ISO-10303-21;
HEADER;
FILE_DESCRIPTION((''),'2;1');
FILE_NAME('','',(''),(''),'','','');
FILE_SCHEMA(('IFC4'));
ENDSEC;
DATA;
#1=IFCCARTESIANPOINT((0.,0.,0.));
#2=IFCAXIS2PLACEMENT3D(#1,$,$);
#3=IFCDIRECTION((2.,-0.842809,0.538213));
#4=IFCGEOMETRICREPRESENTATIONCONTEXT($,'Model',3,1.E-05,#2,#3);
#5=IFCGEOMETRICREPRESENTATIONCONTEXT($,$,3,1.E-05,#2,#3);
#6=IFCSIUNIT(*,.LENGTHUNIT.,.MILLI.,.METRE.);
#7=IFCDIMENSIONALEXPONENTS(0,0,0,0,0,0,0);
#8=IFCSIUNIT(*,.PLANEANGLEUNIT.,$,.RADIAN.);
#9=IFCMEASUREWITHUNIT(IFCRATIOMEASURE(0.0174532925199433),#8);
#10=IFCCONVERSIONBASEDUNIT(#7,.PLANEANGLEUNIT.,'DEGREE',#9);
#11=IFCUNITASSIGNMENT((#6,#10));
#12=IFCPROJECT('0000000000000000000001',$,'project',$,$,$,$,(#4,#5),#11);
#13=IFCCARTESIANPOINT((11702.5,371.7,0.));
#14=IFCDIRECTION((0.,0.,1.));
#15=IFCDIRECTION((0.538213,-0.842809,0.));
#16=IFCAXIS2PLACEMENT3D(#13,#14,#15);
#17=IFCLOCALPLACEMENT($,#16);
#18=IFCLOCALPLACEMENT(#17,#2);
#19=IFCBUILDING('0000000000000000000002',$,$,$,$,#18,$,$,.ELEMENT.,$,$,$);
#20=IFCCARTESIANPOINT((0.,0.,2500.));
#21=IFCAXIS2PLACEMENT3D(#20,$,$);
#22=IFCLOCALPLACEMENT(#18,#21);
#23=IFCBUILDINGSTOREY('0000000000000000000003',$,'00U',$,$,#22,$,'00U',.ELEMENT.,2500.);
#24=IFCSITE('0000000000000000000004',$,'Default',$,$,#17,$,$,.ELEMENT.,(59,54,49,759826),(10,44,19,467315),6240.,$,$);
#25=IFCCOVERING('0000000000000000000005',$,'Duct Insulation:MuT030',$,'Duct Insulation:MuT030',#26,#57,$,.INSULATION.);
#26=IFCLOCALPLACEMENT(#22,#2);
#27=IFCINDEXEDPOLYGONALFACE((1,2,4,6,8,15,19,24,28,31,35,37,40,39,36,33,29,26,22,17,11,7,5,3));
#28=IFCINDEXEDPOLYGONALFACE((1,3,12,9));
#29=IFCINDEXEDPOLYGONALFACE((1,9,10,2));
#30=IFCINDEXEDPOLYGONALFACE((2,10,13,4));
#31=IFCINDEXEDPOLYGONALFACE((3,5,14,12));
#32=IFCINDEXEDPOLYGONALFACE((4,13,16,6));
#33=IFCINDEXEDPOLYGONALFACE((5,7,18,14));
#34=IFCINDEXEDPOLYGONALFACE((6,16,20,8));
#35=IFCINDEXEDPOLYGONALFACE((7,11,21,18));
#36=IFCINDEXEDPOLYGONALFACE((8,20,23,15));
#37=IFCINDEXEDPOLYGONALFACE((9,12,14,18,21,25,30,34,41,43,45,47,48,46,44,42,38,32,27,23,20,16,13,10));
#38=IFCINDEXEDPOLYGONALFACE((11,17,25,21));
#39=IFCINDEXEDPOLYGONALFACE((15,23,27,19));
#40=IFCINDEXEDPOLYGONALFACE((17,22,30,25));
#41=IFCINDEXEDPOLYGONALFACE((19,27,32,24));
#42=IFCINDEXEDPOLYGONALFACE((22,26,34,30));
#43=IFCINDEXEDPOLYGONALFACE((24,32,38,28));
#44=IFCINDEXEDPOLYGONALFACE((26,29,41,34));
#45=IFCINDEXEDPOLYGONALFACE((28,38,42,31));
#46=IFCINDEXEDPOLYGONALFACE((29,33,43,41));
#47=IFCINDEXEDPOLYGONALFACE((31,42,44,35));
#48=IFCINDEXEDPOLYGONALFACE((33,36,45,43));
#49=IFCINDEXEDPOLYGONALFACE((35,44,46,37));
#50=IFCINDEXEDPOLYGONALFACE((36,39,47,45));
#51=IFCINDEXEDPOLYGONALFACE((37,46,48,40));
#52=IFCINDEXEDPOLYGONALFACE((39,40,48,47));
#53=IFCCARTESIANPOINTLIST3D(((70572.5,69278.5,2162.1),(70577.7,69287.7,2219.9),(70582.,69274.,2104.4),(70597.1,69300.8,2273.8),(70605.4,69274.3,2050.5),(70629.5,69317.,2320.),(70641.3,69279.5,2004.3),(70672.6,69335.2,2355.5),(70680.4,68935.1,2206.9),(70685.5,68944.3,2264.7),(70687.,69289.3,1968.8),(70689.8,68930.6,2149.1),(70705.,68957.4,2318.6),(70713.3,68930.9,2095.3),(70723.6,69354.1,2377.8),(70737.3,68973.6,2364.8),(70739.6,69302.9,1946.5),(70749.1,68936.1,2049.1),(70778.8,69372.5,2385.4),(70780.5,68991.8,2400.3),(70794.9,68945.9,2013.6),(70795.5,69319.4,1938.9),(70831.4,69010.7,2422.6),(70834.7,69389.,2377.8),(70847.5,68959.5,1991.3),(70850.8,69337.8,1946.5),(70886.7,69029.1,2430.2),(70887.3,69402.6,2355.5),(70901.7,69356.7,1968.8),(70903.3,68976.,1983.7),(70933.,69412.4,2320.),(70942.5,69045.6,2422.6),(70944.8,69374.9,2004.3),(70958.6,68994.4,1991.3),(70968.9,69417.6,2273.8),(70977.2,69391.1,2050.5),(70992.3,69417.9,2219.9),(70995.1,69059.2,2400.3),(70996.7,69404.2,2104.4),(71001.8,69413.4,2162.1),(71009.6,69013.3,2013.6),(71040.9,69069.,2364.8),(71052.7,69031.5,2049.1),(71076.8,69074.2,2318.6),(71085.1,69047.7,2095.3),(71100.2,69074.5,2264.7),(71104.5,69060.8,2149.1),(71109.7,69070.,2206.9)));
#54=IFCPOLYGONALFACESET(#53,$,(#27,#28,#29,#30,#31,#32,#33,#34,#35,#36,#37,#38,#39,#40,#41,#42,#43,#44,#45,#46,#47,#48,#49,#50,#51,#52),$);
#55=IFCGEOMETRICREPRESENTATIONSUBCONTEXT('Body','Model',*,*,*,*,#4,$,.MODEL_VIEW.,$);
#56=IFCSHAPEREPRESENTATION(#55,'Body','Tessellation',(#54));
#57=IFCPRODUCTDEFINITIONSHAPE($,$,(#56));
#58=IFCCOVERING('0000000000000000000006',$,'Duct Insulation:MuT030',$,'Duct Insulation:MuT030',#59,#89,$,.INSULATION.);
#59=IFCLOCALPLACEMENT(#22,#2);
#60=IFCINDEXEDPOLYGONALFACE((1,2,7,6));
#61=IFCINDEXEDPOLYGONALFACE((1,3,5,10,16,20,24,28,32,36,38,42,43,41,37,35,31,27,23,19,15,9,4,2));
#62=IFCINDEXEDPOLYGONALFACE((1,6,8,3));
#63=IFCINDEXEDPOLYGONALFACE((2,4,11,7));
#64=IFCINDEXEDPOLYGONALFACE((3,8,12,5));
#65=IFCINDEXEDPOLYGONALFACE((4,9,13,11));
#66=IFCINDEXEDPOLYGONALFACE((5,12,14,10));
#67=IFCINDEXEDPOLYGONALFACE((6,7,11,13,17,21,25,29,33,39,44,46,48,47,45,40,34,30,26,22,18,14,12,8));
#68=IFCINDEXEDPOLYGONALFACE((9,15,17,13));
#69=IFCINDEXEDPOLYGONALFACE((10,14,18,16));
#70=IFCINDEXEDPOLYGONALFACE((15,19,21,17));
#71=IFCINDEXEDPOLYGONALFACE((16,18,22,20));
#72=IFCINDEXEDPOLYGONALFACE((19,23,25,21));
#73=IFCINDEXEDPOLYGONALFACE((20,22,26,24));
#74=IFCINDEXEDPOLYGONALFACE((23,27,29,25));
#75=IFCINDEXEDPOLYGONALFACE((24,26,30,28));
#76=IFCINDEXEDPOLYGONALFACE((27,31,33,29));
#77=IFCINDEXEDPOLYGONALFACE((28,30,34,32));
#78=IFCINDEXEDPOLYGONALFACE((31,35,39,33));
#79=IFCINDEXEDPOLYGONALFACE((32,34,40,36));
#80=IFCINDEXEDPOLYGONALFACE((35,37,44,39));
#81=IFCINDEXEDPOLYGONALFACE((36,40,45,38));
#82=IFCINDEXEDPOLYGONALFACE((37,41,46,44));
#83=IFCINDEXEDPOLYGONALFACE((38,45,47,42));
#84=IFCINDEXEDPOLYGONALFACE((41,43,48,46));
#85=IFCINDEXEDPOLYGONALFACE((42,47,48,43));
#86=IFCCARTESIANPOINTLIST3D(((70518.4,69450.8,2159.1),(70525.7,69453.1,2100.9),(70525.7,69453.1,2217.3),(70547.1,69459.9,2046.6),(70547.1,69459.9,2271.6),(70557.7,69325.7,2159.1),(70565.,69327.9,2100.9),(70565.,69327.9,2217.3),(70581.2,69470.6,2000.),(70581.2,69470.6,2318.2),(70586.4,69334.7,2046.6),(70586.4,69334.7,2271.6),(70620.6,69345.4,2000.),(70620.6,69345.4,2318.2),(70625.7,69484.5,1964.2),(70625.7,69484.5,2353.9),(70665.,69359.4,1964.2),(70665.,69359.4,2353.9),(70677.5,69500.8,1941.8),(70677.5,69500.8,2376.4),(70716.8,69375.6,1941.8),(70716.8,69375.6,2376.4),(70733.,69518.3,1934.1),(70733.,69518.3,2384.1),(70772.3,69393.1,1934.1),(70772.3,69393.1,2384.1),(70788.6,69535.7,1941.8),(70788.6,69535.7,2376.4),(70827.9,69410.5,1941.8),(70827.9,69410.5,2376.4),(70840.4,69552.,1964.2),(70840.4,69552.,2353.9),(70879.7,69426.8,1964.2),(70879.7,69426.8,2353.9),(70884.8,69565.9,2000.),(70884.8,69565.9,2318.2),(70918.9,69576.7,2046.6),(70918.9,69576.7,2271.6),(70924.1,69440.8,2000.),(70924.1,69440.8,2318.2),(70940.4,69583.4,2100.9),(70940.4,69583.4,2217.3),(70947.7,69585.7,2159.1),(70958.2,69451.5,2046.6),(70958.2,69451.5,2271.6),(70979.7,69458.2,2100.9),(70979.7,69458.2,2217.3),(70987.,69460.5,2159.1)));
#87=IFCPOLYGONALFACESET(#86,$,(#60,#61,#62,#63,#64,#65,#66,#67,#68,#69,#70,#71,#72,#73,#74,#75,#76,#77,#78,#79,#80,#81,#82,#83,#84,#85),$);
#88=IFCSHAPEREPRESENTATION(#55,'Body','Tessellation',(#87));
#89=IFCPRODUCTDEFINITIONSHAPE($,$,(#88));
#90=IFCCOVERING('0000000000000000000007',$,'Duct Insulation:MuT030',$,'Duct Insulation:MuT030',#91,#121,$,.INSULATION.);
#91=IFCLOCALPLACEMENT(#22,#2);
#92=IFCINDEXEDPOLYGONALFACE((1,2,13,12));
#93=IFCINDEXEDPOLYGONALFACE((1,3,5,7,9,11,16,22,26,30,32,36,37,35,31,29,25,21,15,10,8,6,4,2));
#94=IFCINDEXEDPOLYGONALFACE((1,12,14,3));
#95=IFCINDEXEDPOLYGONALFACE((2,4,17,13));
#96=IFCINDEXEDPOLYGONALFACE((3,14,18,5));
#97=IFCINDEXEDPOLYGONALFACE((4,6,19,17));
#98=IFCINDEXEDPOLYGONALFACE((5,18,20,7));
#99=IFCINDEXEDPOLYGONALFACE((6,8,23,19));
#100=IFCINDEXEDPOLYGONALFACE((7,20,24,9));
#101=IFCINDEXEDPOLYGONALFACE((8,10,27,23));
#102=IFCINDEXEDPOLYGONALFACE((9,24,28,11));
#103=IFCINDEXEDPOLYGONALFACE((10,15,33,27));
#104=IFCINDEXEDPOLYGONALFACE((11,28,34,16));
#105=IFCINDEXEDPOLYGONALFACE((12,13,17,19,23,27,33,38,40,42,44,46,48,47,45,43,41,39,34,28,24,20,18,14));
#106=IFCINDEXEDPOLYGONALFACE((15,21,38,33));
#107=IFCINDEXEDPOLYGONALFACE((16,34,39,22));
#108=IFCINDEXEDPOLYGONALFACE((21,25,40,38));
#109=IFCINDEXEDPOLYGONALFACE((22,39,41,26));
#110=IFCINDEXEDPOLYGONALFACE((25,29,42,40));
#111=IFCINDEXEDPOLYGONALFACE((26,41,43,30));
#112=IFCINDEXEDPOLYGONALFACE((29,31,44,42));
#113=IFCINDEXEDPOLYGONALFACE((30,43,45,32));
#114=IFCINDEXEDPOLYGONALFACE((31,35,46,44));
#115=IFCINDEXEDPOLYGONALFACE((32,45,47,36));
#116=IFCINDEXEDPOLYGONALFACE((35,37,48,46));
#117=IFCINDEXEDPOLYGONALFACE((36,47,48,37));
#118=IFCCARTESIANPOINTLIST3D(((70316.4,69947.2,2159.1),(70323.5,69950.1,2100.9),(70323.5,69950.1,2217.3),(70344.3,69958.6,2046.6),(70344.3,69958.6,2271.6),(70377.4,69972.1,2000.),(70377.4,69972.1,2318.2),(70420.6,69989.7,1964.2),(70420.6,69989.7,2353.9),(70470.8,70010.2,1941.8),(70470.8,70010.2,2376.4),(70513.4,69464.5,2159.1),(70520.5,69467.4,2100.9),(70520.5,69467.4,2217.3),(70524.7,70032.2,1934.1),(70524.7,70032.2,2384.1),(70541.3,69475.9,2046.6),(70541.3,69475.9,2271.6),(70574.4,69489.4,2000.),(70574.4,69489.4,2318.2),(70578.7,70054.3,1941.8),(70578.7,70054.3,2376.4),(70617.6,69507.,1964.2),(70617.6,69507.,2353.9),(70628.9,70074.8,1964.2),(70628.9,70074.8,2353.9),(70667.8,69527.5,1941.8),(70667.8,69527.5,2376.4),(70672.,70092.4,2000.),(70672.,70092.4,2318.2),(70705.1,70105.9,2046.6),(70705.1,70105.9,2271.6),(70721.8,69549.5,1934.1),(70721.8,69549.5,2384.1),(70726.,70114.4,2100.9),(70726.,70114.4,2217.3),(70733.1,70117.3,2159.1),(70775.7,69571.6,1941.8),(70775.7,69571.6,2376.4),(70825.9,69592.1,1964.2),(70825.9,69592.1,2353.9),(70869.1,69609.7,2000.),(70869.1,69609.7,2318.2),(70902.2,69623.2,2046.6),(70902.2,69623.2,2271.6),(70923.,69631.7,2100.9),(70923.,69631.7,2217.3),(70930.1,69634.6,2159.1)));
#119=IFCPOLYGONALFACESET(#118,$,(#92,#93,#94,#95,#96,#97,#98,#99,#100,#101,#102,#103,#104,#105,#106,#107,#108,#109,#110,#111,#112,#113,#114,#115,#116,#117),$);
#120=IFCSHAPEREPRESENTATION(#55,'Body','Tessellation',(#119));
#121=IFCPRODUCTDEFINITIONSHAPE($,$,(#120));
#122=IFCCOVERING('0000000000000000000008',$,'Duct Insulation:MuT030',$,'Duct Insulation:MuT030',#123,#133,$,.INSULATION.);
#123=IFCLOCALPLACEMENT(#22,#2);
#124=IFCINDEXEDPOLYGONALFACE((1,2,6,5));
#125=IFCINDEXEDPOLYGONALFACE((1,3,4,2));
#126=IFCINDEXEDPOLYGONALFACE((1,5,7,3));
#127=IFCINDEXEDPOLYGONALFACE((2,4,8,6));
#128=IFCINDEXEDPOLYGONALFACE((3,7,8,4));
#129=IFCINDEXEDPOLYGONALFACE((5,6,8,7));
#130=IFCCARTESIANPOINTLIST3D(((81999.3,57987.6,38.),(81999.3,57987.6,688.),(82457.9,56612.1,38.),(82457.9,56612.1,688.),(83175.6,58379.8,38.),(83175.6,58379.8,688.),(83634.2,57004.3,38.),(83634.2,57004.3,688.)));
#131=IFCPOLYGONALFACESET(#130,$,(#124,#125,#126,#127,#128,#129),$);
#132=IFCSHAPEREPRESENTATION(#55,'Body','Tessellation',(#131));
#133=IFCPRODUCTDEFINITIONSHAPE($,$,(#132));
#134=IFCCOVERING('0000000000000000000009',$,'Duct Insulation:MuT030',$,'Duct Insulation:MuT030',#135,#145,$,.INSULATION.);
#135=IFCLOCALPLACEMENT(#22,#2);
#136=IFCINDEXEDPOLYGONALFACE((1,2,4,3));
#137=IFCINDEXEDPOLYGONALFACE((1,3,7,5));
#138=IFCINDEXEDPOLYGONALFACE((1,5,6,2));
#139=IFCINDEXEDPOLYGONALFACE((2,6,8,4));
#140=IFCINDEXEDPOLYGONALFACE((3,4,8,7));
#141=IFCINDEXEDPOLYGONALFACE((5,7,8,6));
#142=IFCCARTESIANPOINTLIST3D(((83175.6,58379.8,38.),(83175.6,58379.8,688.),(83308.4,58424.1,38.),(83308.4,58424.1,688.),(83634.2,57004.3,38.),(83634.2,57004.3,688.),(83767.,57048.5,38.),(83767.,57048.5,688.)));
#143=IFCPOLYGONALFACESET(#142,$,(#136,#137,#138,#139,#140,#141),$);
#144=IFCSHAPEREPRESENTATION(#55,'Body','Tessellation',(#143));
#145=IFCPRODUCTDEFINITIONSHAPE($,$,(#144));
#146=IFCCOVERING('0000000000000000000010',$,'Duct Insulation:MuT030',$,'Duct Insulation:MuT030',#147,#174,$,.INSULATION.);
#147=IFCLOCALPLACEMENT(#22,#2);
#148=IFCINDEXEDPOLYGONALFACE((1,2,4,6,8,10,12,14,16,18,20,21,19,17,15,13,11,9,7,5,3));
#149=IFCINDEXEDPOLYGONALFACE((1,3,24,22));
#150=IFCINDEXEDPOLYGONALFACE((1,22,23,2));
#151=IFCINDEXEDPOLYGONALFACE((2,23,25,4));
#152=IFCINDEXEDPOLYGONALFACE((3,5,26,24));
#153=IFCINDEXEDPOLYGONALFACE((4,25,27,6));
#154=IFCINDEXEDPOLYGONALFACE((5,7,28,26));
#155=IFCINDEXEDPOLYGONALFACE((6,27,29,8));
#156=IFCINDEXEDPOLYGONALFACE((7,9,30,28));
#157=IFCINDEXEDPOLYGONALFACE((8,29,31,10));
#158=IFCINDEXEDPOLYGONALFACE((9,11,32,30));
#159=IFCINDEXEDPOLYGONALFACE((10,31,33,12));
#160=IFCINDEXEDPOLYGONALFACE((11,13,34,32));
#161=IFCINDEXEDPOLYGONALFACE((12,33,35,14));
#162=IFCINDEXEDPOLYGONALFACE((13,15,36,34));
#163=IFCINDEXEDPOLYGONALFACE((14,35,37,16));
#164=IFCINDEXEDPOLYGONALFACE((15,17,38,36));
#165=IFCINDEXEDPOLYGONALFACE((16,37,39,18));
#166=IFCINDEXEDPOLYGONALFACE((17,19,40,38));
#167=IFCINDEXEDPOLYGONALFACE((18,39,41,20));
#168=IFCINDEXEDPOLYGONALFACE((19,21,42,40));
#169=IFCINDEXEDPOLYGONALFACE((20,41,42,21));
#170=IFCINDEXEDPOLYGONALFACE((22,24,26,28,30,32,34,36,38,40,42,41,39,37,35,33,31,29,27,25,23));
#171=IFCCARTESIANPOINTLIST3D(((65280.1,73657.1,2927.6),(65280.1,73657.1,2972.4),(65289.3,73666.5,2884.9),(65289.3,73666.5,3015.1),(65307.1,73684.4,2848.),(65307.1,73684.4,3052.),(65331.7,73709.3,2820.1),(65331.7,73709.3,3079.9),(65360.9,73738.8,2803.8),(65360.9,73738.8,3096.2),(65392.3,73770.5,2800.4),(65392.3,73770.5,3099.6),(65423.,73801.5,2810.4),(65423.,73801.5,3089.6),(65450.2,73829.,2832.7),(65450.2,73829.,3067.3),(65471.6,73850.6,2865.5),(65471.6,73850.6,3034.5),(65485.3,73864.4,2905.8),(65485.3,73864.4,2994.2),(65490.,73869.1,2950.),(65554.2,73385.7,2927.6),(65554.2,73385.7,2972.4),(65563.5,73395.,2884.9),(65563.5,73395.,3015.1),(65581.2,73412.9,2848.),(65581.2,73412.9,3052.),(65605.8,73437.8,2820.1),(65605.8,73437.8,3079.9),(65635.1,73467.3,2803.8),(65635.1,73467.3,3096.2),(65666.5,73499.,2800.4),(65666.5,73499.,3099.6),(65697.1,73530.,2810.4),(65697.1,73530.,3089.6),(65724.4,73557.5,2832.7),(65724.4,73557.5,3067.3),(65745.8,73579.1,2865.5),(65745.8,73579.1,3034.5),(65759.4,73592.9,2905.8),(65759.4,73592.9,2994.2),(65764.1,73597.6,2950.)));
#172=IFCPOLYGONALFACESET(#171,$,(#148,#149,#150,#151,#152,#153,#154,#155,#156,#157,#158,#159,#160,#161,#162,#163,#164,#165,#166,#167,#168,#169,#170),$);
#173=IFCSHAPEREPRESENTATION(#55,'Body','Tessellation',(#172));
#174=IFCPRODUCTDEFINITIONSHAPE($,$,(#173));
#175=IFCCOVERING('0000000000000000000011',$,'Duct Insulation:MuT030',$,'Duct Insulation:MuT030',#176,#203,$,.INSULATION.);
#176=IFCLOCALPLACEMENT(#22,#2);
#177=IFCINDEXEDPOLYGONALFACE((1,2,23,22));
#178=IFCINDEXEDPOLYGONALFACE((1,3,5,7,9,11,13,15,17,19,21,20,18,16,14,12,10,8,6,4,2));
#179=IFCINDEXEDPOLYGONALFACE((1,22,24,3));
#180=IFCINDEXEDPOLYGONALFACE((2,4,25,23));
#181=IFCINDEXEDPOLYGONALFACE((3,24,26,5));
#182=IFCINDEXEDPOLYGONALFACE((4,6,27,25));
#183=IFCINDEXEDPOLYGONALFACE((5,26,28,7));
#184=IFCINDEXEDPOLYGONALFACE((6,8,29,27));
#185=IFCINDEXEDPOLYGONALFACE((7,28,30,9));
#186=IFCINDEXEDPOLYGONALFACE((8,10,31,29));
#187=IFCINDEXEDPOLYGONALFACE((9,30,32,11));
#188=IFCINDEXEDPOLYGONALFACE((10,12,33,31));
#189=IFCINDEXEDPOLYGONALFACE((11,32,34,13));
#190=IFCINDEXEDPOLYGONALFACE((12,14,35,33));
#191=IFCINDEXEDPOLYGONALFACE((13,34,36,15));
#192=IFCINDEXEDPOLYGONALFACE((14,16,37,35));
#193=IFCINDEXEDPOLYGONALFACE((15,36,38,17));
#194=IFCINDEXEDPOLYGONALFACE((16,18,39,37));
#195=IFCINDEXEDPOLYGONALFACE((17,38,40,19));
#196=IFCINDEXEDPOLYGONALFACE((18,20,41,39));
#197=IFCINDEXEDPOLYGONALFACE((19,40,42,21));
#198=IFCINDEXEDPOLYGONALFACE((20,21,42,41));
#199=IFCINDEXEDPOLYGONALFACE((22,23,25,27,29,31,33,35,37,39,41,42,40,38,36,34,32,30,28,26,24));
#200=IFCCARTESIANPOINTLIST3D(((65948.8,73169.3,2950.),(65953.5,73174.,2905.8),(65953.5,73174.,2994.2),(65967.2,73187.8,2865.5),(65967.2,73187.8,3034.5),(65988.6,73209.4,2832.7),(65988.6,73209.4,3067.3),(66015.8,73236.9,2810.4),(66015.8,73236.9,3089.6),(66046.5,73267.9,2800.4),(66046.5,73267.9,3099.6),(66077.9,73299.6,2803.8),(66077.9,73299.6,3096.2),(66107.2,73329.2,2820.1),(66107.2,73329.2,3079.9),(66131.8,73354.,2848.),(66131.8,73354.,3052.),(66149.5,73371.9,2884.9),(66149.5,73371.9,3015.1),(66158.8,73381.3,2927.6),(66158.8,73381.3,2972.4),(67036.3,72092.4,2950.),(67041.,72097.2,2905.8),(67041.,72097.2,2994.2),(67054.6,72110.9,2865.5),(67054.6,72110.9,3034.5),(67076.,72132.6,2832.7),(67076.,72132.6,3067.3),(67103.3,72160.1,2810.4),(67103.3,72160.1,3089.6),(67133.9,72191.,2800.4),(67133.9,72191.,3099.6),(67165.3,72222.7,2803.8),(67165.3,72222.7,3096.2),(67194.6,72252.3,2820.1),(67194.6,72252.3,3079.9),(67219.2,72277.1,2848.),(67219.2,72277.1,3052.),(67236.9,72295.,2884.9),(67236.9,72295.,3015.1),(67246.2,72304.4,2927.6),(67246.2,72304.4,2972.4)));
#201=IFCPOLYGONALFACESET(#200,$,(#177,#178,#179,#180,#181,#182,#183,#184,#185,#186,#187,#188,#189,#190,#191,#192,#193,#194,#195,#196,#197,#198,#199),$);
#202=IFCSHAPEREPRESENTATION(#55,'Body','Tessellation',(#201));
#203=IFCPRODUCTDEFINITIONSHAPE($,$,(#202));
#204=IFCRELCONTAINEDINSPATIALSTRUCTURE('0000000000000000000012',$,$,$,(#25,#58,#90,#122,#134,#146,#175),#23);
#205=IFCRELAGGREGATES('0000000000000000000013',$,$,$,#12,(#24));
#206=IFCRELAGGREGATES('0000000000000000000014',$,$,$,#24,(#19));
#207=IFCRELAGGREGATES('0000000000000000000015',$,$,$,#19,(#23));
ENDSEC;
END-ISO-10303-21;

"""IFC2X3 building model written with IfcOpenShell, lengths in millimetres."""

from ifc_helpers import new_model, entity, si_unit, converted_unit, direction, frame, frame_2d, origin, origin_2d_with_axis, place, context, subcontext, project, spatial, rectangle, circle, extrude, element, save


model = new_model("IFC2X3")

# Units and contexts
model_context = context("Model", 3, precision=1e-05, world=origin(), true_north=direction((2.0, -0.842809, 0.538213)))
context_of_model = context(None, 3, precision=1e-05, world=origin(), true_north=direction((2.0, -0.842809, 0.538213)))
body_context = subcontext(model_context, "Body", "Model", "MODEL_VIEW")
ifc_project = project(units=[si_unit("LENGTHUNIT", "METRE", prefix="MILLI"), converted_unit("PLANEANGLEUNIT", "DEGREE", entity("IfcRatioMeasure", 0.0174532925199433), si_unit("PLANEANGLEUNIT", "RADIAN"), dimensions=[0, 0, 0, 0, 0, 0, 0])], contexts=[model_context, context_of_model])

# Site, building, storey
site_placement = place(None, frame((11702.5, 371.7, 0.0), z_axis=(0.0, 0.0, 1.0), x_axis=(0.538213, -0.842809, 0.0)))
site = spatial("IfcSite", under=ifc_project, at=site_placement, Name="Default", CompositionType="ELEMENT", RefLatitude=(59, 54, 49, 759826), RefLongitude=(10, 44, 19, 467315), RefElevation=6240.0)
building_placement = place(site_placement, origin())
building = spatial("IfcBuilding", under=site, at=building_placement, CompositionType="ELEMENT")
storey_placement = place(building_placement, frame((0.0, 0.0, 2500.0)))
storey = spatial("IfcBuildingStorey", under=building, at=storey_placement, Name="00U", LongName="00U", CompositionType="ELEMENT", Elevation=2500.0)

# Coverings
covering_1_placement = place(storey_placement, origin())
element("IfcCovering", 1, at=covering_1_placement, inside=storey, Name="Duct Insulation:MuT030", ObjectType="Duct Insulation:MuT030", PredefinedType="INSULATION", context=body_context, shape_type="SweptSolid", body=[
    extrude(circle(Radius=225.0, at=frame_2d((0.0, 0.0), x_axis=(1.0, 0.0))), frame((70895.0, 69002.5, 2206.9), z_axis=(-0.297378, 0.94674, -0.123488), x_axis=(-0.954042, -0.299672, 0.0)), (0.0, 0.0, 1.0), 362.7),
])
covering_2_placement = place(storey_placement, origin())
element("IfcCovering", 2, at=covering_2_placement, inside=storey, Name="Duct Insulation:MuT030", ObjectType="Duct Insulation:MuT030", PredefinedType="INSULATION", context=body_context, shape_type="SweptSolid", body=[
    extrude(circle(Radius=225.0, at=frame_2d((0.0, 0.0), x_axis=(1.0, 0.0))), frame((70772.3, 69393.1, 2159.1), z_axis=(-0.299672, 0.954042, 0.0), x_axis=(-0.954042, -0.299672, 0.0)), (0.0, 0.0, 1.0), 131.2),
])
covering_3_placement = place(storey_placement, origin())
element("IfcCovering", 3, at=covering_3_placement, inside=storey, Name="Duct Insulation:MuT030", ObjectType="Duct Insulation:MuT030", PredefinedType="INSULATION", context=body_context, shape_type="SweptSolid", body=[
    extrude(circle(Radius=225.0, at=origin_2d_with_axis()), frame((70721.8, 69549.5, 2159.1), z_axis=(-0.377887, 0.925852, 0.0), x_axis=(0.925852, 0.377887, 0.0)), (0.0, 0.0, 1.0), 521.4),
])
covering_4_placement = place(storey_placement, origin())
element("IfcCovering", 4, at=covering_4_placement, inside=storey, Name="Duct Insulation:MuT030", ObjectType="Duct Insulation:MuT030", PredefinedType="INSULATION", context=body_context, shape_type="SweptSolid", body=[
    extrude(rectangle(XDim=1240.0, YDim=1450.0, at=frame_2d((0.0, 0.0), x_axis=(1.0, 0.0))), frame((82816.8, 57496.0, 38.0), z_axis=(0.0, 0.0, 1.0), x_axis=(-0.948667, -0.316277, 0.0)), (0.0, 0.0, 1.0), 650.0),
])
covering_5_placement = place(storey_placement, origin())
element("IfcCovering", 5, at=covering_5_placement, inside=storey, Name="Duct Insulation:MuT030", ObjectType="Duct Insulation:MuT030", PredefinedType="INSULATION", context=body_context, shape_type="SweptSolid", body=[
    extrude(rectangle(XDim=140.0, YDim=1450.0, at=frame_2d((0.0, 0.0), x_axis=(1.0, 0.0))), frame((83471.3, 57714.2, 38.0), z_axis=(0.0, 0.0, 1.0), x_axis=(0.948667, 0.316277, 0.0)), (0.0, 0.0, 1.0), 650.0),
])
covering_6_placement = place(storey_placement, origin())
element("IfcCovering", 6, at=covering_6_placement, inside=storey, Name="Duct Insulation:MuT030", ObjectType="Duct Insulation:MuT030", PredefinedType="INSULATION", context=body_context, shape_type="SweptSolid", body=[
    extrude(circle(Radius=150.0, at=frame_2d((0.0, 0.0), x_axis=(1.0, 0.0))), frame((65658.6, 73491.1, 2950.0), z_axis=(-0.710554, 0.703643, 0.0), x_axis=(0.703643, 0.710554, 0.0)), (0.0, 0.0, 1.0), 385.8),
])
covering_7_placement = place(storey_placement, origin())
element("IfcCovering", 7, at=covering_7_placement, inside=storey, Name="Duct Insulation:MuT030", ObjectType="Duct Insulation:MuT030", PredefinedType="INSULATION", context=body_context, shape_type="SweptSolid", body=[
    extrude(circle(Radius=150.0, at=origin_2d_with_axis()), frame((67141.8, 72199.0, 2950.0), z_axis=(-0.710554, 0.703643, 0.0), x_axis=(-0.703643, -0.710554, 0.0)), (0.0, 0.0, 1.0), 1530.4),
])

save(model, "model.ifc")
